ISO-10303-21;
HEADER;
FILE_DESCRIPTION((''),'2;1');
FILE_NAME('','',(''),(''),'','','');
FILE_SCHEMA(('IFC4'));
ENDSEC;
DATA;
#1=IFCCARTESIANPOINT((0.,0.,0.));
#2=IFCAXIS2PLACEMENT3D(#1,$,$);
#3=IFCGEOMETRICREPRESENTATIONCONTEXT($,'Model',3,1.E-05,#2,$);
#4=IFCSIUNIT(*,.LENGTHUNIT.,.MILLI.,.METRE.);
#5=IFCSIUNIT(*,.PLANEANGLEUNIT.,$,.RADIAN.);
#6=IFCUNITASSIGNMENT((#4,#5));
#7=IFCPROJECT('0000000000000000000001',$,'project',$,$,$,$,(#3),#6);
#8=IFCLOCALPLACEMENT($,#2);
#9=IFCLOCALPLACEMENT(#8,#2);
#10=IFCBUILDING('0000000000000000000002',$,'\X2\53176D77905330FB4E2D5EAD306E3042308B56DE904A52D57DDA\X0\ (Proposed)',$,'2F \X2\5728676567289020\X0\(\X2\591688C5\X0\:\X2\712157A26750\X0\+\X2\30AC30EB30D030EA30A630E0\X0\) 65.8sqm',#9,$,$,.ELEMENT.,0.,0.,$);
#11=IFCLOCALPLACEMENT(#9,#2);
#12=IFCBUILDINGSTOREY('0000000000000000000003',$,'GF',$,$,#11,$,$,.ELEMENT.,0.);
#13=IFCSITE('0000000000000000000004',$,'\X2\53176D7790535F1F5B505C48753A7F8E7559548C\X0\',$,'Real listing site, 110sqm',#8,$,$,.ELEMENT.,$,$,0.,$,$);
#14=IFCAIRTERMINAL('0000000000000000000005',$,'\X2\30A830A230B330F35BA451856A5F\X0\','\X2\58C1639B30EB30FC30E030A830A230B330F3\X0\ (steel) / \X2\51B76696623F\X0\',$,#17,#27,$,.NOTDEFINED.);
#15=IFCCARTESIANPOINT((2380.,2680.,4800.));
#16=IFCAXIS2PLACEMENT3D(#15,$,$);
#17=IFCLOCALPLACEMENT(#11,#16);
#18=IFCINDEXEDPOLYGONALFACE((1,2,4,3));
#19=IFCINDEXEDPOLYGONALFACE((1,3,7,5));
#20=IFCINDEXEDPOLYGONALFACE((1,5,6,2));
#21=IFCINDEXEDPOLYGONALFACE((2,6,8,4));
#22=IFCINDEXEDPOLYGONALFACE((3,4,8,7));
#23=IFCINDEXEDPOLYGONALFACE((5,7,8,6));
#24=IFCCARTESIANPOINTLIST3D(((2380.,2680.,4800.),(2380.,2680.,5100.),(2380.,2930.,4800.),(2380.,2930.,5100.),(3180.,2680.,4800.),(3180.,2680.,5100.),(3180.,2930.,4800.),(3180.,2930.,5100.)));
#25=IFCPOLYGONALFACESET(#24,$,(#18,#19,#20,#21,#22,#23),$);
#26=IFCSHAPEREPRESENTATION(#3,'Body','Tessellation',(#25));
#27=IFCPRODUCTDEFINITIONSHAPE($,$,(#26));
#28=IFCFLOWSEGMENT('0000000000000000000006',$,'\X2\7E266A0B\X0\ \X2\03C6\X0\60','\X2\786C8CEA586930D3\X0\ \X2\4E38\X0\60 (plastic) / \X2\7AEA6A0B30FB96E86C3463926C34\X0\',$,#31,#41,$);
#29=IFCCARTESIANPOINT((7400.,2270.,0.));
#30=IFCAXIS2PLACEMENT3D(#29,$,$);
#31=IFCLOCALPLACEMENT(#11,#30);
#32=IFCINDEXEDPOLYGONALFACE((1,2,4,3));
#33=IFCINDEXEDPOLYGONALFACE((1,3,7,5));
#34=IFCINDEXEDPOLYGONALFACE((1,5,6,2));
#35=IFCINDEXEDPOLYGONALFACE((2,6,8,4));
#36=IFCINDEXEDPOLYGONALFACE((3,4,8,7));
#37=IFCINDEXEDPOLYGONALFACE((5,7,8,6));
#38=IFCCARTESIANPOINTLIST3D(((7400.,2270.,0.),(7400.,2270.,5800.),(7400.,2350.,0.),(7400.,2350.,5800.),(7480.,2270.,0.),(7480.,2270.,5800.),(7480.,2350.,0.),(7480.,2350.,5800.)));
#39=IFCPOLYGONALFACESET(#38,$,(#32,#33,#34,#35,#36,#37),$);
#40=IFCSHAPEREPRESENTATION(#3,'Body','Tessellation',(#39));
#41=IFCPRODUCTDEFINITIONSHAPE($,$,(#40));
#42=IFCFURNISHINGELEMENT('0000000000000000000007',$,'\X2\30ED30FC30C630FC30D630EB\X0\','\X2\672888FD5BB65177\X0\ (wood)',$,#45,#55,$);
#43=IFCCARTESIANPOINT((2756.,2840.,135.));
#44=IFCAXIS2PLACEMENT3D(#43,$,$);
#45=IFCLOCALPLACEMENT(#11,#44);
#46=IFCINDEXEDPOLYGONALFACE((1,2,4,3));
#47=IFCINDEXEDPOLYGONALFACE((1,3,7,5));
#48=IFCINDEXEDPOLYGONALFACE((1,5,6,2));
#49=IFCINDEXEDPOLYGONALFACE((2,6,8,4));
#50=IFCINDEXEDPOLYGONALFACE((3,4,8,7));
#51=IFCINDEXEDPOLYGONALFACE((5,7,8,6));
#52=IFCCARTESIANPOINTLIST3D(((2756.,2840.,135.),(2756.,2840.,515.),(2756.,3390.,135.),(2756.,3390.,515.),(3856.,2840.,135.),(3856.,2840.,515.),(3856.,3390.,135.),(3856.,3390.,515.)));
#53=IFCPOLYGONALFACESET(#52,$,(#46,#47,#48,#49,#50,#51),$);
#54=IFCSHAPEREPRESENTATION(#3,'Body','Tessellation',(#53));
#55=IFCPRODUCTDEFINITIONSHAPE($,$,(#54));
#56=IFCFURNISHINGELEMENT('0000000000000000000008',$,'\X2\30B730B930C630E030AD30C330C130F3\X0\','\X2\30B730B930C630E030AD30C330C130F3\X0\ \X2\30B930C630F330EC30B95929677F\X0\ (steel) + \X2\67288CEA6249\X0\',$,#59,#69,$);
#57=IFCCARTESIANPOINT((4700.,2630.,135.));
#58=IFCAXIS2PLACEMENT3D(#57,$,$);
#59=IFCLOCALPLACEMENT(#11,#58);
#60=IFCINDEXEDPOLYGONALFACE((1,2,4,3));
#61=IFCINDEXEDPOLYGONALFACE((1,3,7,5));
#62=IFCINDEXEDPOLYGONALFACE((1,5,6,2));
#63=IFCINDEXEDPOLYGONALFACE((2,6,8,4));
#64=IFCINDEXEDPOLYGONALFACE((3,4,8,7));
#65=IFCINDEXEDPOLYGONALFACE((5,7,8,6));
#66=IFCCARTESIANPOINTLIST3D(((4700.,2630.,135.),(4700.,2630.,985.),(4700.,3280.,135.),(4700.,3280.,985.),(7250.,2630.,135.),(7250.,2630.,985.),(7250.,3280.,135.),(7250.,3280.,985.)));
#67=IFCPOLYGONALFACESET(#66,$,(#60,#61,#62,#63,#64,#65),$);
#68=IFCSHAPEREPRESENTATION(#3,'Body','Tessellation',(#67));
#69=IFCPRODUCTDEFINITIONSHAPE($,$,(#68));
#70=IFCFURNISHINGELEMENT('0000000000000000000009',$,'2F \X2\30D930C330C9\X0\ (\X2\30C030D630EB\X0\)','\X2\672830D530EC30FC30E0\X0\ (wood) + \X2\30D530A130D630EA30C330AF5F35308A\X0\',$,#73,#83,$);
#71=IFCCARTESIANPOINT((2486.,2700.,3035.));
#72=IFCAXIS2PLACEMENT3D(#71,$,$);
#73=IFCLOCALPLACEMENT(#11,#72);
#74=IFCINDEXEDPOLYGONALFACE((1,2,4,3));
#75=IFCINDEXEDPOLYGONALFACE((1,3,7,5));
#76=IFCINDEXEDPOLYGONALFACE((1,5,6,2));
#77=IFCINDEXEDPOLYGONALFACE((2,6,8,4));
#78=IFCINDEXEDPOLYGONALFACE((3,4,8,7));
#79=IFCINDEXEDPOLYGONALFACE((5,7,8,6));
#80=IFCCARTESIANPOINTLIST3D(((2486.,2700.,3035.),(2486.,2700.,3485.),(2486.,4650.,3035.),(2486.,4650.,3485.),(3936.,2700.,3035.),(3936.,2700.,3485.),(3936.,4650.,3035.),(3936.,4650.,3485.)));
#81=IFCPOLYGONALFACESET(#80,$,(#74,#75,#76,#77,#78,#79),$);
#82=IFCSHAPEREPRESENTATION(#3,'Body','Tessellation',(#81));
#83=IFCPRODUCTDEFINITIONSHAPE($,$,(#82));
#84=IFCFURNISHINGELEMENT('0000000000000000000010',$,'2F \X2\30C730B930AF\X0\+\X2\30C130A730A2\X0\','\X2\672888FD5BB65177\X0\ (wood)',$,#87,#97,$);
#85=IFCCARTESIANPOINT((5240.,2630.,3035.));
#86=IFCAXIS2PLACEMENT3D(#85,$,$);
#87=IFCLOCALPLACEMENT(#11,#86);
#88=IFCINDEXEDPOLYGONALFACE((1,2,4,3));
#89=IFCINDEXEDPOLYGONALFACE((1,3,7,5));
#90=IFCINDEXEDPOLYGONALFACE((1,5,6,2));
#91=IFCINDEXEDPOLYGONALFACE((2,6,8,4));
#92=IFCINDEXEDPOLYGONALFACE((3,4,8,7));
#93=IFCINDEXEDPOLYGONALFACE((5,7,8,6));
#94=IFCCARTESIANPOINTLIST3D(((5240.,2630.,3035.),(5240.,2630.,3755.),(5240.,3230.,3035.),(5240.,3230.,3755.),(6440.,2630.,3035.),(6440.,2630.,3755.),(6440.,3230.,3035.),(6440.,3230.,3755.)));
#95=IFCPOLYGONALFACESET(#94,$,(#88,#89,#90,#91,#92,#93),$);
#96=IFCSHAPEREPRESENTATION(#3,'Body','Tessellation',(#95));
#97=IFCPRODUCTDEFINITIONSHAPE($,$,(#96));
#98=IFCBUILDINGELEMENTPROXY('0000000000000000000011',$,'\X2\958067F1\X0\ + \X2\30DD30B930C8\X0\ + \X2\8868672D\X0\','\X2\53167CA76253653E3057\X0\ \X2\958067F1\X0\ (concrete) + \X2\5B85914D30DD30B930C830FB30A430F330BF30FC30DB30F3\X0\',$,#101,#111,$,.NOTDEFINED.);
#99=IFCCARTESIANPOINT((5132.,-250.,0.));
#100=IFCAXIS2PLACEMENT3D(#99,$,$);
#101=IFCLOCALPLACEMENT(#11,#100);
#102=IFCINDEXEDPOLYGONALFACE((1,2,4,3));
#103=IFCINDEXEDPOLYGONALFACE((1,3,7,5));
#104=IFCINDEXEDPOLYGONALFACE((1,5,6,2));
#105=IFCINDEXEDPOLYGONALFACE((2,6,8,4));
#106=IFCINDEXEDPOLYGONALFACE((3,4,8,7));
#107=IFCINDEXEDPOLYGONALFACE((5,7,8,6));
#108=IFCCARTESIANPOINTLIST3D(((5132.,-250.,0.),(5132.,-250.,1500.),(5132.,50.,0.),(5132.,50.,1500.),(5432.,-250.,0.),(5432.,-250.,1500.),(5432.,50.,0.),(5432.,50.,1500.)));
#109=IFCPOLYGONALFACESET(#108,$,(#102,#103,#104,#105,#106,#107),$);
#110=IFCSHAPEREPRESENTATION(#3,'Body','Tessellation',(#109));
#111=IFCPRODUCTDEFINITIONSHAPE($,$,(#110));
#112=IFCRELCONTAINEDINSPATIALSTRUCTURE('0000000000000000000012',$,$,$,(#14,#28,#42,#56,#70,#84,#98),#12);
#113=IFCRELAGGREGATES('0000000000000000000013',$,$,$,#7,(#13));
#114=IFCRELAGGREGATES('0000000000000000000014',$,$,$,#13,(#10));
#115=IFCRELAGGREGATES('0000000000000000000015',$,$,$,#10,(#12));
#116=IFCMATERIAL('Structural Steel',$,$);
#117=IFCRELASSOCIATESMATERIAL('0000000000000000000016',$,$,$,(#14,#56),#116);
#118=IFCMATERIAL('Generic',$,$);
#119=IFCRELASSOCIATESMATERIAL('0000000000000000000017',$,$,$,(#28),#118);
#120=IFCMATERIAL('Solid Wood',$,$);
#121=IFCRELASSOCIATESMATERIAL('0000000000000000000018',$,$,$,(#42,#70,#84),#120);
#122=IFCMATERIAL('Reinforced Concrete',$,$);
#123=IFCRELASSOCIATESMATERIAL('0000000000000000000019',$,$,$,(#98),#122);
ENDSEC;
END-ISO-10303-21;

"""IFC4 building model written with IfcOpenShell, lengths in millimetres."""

from ifc_helpers import new_model, si_unit, frame, frame_2d, origin, place, context, project, spatial, rectangle, extrude, material, element, save


model = new_model("IFC4")

# Units and contexts
model_context = context("Model", 3, precision=1e-05, world=origin())
ifc_project = project(units=[si_unit("LENGTHUNIT", "METRE", prefix="MILLI"), si_unit("PLANEANGLEUNIT", "RADIAN")], contexts=[model_context])

# Site, building, storey
site_placement = place(None, origin())
site = spatial("IfcSite", under=ifc_project, at=site_placement, Name="北海道弟子屈町美留和", ObjectType="Real listing site, 110sqm", CompositionType="ELEMENT", RefElevation=0.0)
building_placement = place(site_placement, origin())
building = spatial("IfcBuilding", under=site, at=building_placement, Name="北海道・中庭のある回遊動線 (Proposed)", ObjectType="2F 在来木造(外装:無垢材+ガルバリウム) 65.8sqm", CompositionType="ELEMENT", ElevationOfRefHeight=0.0, ElevationOfTerrain=0.0)
storey_placement = place(building_placement, origin())
storey = spatial("IfcBuildingStorey", under=building, at=storey_placement, Name="GF", CompositionType="ELEMENT", Elevation=0.0)

# Shared definitions
ifc_material_1 = material(Name="Solid Wood")

# Shared definitions
ifc_material_2 = material(Name="Reinforced Concrete")

# Shared definitions
ifc_material_3 = material(Name="Structural Steel")

# Shared definitions
ifc_material_4 = material(Name="Generic")

# Air terminal
air_terminal_placement = place(storey_placement, frame((2380.0, 2680.0, 4800.0)))
element("IfcAirTerminal", 1, at=air_terminal_placement, inside=storey, material=ifc_material_3, Name="エアコン室内機", Description="壁掛ルームエアコン (steel) / 冷暖房", PredefinedType="NOTDEFINED", context=model_context, shape_type="SweptSolid", body=[
    extrude(rectangle(XDim=800.0, YDim=250.0, at=frame_2d((400.0, 125.0))), frame((2380.0, 2680.0, 4800.0)), (0.0, 0.0, 1.0), 300.0),
])

# Flow segment
flow_segment_placement = place(storey_placement, frame((7400.0, 2270.0, 0.0)))
element("IfcFlowSegment", 2, at=flow_segment_placement, inside=storey, material=ifc_material_4, Name="縦樋 φ60", Description="硬質塩ビ 丸60 (plastic) / 竪樋・雨水排水", context=model_context, shape_type="SweptSolid", body=[
    extrude(rectangle(XDim=80.0, YDim=80.0, at=frame_2d((40.0, 40.0))), frame((7400.0, 2270.0, 0.0)), (0.0, 0.0, 1.0), 5800.0),
])

# Furnishing elements
furnishing_1_placement = place(storey_placement, frame((2756.0, 2840.0, 135.0)))
element("IfcFurnishingElement", 3, at=furnishing_1_placement, inside=storey, material=ifc_material_1, Name="ローテーブル", Description="木製家具 (wood)", context=model_context, shape_type="SweptSolid", body=[
    extrude(rectangle(XDim=1100.0, YDim=550.0, at=frame_2d((550.0, 275.0))), frame((2756.0, 2840.0, 135.0)), (0.0, 0.0, 1.0), 380.0),
])
furnishing_2_placement = place(storey_placement, frame((4700.0, 2630.0, 135.0)))
element("IfcFurnishingElement", 4, at=furnishing_2_placement, inside=storey, material=ifc_material_3, Name="システムキッチン", Description="システムキッチン ステンレス天板 (steel) + 木質扉", context=model_context, shape_type="SweptSolid", body=[
    extrude(rectangle(XDim=2550.0, YDim=650.0, at=frame_2d((1275.0, 325.0))), frame((4700.0, 2630.0, 135.0)), (0.0, 0.0, 1.0), 850.0),
])
furnishing_3_placement = place(storey_placement, frame((2486.0, 2700.0, 3035.0)))
element("IfcFurnishingElement", 5, at=furnishing_3_placement, inside=storey, material=ifc_material_1, Name="2F ベッド (ダブル)", Description="木フレーム (wood) + ファブリック張り", context=model_context, shape_type="SweptSolid", body=[
    extrude(rectangle(XDim=1450.0, YDim=1950.0, at=frame_2d((725.0, 975.0))), frame((2486.0, 2700.0, 3035.0)), (0.0, 0.0, 1.0), 450.0),
])
furnishing_4_placement = place(storey_placement, frame((5240.0, 2630.0, 3035.0)))
element("IfcFurnishingElement", 6, at=furnishing_4_placement, inside=storey, material=ifc_material_1, Name="2F デスク+チェア", Description="木製家具 (wood)", context=model_context, shape_type="SweptSolid", body=[
    extrude(rectangle(XDim=1200.0, YDim=600.0, at=frame_2d((600.0, 300.0))), frame((5240.0, 2630.0, 3035.0)), (0.0, 0.0, 1.0), 720.0),
])

# Building element proxy
proxy_placement = place(storey_placement, frame((5132.0, -250.0, 0.0)))
element("IfcBuildingElementProxy", 7, at=proxy_placement, inside=storey, material=ifc_material_2, Name="門柱 + ポスト + 表札", Description="化粧打放し 門柱 (concrete) + 宅配ポスト・インターホン", PredefinedType="NOTDEFINED", context=model_context, shape_type="SweptSolid", body=[
    extrude(rectangle(XDim=300.0, YDim=300.0, at=frame_2d((150.0, 150.0))), frame((5132.0, -250.0, 0.0)), (0.0, 0.0, 1.0), 1500.0),
])

save(model, "model.ifc")
